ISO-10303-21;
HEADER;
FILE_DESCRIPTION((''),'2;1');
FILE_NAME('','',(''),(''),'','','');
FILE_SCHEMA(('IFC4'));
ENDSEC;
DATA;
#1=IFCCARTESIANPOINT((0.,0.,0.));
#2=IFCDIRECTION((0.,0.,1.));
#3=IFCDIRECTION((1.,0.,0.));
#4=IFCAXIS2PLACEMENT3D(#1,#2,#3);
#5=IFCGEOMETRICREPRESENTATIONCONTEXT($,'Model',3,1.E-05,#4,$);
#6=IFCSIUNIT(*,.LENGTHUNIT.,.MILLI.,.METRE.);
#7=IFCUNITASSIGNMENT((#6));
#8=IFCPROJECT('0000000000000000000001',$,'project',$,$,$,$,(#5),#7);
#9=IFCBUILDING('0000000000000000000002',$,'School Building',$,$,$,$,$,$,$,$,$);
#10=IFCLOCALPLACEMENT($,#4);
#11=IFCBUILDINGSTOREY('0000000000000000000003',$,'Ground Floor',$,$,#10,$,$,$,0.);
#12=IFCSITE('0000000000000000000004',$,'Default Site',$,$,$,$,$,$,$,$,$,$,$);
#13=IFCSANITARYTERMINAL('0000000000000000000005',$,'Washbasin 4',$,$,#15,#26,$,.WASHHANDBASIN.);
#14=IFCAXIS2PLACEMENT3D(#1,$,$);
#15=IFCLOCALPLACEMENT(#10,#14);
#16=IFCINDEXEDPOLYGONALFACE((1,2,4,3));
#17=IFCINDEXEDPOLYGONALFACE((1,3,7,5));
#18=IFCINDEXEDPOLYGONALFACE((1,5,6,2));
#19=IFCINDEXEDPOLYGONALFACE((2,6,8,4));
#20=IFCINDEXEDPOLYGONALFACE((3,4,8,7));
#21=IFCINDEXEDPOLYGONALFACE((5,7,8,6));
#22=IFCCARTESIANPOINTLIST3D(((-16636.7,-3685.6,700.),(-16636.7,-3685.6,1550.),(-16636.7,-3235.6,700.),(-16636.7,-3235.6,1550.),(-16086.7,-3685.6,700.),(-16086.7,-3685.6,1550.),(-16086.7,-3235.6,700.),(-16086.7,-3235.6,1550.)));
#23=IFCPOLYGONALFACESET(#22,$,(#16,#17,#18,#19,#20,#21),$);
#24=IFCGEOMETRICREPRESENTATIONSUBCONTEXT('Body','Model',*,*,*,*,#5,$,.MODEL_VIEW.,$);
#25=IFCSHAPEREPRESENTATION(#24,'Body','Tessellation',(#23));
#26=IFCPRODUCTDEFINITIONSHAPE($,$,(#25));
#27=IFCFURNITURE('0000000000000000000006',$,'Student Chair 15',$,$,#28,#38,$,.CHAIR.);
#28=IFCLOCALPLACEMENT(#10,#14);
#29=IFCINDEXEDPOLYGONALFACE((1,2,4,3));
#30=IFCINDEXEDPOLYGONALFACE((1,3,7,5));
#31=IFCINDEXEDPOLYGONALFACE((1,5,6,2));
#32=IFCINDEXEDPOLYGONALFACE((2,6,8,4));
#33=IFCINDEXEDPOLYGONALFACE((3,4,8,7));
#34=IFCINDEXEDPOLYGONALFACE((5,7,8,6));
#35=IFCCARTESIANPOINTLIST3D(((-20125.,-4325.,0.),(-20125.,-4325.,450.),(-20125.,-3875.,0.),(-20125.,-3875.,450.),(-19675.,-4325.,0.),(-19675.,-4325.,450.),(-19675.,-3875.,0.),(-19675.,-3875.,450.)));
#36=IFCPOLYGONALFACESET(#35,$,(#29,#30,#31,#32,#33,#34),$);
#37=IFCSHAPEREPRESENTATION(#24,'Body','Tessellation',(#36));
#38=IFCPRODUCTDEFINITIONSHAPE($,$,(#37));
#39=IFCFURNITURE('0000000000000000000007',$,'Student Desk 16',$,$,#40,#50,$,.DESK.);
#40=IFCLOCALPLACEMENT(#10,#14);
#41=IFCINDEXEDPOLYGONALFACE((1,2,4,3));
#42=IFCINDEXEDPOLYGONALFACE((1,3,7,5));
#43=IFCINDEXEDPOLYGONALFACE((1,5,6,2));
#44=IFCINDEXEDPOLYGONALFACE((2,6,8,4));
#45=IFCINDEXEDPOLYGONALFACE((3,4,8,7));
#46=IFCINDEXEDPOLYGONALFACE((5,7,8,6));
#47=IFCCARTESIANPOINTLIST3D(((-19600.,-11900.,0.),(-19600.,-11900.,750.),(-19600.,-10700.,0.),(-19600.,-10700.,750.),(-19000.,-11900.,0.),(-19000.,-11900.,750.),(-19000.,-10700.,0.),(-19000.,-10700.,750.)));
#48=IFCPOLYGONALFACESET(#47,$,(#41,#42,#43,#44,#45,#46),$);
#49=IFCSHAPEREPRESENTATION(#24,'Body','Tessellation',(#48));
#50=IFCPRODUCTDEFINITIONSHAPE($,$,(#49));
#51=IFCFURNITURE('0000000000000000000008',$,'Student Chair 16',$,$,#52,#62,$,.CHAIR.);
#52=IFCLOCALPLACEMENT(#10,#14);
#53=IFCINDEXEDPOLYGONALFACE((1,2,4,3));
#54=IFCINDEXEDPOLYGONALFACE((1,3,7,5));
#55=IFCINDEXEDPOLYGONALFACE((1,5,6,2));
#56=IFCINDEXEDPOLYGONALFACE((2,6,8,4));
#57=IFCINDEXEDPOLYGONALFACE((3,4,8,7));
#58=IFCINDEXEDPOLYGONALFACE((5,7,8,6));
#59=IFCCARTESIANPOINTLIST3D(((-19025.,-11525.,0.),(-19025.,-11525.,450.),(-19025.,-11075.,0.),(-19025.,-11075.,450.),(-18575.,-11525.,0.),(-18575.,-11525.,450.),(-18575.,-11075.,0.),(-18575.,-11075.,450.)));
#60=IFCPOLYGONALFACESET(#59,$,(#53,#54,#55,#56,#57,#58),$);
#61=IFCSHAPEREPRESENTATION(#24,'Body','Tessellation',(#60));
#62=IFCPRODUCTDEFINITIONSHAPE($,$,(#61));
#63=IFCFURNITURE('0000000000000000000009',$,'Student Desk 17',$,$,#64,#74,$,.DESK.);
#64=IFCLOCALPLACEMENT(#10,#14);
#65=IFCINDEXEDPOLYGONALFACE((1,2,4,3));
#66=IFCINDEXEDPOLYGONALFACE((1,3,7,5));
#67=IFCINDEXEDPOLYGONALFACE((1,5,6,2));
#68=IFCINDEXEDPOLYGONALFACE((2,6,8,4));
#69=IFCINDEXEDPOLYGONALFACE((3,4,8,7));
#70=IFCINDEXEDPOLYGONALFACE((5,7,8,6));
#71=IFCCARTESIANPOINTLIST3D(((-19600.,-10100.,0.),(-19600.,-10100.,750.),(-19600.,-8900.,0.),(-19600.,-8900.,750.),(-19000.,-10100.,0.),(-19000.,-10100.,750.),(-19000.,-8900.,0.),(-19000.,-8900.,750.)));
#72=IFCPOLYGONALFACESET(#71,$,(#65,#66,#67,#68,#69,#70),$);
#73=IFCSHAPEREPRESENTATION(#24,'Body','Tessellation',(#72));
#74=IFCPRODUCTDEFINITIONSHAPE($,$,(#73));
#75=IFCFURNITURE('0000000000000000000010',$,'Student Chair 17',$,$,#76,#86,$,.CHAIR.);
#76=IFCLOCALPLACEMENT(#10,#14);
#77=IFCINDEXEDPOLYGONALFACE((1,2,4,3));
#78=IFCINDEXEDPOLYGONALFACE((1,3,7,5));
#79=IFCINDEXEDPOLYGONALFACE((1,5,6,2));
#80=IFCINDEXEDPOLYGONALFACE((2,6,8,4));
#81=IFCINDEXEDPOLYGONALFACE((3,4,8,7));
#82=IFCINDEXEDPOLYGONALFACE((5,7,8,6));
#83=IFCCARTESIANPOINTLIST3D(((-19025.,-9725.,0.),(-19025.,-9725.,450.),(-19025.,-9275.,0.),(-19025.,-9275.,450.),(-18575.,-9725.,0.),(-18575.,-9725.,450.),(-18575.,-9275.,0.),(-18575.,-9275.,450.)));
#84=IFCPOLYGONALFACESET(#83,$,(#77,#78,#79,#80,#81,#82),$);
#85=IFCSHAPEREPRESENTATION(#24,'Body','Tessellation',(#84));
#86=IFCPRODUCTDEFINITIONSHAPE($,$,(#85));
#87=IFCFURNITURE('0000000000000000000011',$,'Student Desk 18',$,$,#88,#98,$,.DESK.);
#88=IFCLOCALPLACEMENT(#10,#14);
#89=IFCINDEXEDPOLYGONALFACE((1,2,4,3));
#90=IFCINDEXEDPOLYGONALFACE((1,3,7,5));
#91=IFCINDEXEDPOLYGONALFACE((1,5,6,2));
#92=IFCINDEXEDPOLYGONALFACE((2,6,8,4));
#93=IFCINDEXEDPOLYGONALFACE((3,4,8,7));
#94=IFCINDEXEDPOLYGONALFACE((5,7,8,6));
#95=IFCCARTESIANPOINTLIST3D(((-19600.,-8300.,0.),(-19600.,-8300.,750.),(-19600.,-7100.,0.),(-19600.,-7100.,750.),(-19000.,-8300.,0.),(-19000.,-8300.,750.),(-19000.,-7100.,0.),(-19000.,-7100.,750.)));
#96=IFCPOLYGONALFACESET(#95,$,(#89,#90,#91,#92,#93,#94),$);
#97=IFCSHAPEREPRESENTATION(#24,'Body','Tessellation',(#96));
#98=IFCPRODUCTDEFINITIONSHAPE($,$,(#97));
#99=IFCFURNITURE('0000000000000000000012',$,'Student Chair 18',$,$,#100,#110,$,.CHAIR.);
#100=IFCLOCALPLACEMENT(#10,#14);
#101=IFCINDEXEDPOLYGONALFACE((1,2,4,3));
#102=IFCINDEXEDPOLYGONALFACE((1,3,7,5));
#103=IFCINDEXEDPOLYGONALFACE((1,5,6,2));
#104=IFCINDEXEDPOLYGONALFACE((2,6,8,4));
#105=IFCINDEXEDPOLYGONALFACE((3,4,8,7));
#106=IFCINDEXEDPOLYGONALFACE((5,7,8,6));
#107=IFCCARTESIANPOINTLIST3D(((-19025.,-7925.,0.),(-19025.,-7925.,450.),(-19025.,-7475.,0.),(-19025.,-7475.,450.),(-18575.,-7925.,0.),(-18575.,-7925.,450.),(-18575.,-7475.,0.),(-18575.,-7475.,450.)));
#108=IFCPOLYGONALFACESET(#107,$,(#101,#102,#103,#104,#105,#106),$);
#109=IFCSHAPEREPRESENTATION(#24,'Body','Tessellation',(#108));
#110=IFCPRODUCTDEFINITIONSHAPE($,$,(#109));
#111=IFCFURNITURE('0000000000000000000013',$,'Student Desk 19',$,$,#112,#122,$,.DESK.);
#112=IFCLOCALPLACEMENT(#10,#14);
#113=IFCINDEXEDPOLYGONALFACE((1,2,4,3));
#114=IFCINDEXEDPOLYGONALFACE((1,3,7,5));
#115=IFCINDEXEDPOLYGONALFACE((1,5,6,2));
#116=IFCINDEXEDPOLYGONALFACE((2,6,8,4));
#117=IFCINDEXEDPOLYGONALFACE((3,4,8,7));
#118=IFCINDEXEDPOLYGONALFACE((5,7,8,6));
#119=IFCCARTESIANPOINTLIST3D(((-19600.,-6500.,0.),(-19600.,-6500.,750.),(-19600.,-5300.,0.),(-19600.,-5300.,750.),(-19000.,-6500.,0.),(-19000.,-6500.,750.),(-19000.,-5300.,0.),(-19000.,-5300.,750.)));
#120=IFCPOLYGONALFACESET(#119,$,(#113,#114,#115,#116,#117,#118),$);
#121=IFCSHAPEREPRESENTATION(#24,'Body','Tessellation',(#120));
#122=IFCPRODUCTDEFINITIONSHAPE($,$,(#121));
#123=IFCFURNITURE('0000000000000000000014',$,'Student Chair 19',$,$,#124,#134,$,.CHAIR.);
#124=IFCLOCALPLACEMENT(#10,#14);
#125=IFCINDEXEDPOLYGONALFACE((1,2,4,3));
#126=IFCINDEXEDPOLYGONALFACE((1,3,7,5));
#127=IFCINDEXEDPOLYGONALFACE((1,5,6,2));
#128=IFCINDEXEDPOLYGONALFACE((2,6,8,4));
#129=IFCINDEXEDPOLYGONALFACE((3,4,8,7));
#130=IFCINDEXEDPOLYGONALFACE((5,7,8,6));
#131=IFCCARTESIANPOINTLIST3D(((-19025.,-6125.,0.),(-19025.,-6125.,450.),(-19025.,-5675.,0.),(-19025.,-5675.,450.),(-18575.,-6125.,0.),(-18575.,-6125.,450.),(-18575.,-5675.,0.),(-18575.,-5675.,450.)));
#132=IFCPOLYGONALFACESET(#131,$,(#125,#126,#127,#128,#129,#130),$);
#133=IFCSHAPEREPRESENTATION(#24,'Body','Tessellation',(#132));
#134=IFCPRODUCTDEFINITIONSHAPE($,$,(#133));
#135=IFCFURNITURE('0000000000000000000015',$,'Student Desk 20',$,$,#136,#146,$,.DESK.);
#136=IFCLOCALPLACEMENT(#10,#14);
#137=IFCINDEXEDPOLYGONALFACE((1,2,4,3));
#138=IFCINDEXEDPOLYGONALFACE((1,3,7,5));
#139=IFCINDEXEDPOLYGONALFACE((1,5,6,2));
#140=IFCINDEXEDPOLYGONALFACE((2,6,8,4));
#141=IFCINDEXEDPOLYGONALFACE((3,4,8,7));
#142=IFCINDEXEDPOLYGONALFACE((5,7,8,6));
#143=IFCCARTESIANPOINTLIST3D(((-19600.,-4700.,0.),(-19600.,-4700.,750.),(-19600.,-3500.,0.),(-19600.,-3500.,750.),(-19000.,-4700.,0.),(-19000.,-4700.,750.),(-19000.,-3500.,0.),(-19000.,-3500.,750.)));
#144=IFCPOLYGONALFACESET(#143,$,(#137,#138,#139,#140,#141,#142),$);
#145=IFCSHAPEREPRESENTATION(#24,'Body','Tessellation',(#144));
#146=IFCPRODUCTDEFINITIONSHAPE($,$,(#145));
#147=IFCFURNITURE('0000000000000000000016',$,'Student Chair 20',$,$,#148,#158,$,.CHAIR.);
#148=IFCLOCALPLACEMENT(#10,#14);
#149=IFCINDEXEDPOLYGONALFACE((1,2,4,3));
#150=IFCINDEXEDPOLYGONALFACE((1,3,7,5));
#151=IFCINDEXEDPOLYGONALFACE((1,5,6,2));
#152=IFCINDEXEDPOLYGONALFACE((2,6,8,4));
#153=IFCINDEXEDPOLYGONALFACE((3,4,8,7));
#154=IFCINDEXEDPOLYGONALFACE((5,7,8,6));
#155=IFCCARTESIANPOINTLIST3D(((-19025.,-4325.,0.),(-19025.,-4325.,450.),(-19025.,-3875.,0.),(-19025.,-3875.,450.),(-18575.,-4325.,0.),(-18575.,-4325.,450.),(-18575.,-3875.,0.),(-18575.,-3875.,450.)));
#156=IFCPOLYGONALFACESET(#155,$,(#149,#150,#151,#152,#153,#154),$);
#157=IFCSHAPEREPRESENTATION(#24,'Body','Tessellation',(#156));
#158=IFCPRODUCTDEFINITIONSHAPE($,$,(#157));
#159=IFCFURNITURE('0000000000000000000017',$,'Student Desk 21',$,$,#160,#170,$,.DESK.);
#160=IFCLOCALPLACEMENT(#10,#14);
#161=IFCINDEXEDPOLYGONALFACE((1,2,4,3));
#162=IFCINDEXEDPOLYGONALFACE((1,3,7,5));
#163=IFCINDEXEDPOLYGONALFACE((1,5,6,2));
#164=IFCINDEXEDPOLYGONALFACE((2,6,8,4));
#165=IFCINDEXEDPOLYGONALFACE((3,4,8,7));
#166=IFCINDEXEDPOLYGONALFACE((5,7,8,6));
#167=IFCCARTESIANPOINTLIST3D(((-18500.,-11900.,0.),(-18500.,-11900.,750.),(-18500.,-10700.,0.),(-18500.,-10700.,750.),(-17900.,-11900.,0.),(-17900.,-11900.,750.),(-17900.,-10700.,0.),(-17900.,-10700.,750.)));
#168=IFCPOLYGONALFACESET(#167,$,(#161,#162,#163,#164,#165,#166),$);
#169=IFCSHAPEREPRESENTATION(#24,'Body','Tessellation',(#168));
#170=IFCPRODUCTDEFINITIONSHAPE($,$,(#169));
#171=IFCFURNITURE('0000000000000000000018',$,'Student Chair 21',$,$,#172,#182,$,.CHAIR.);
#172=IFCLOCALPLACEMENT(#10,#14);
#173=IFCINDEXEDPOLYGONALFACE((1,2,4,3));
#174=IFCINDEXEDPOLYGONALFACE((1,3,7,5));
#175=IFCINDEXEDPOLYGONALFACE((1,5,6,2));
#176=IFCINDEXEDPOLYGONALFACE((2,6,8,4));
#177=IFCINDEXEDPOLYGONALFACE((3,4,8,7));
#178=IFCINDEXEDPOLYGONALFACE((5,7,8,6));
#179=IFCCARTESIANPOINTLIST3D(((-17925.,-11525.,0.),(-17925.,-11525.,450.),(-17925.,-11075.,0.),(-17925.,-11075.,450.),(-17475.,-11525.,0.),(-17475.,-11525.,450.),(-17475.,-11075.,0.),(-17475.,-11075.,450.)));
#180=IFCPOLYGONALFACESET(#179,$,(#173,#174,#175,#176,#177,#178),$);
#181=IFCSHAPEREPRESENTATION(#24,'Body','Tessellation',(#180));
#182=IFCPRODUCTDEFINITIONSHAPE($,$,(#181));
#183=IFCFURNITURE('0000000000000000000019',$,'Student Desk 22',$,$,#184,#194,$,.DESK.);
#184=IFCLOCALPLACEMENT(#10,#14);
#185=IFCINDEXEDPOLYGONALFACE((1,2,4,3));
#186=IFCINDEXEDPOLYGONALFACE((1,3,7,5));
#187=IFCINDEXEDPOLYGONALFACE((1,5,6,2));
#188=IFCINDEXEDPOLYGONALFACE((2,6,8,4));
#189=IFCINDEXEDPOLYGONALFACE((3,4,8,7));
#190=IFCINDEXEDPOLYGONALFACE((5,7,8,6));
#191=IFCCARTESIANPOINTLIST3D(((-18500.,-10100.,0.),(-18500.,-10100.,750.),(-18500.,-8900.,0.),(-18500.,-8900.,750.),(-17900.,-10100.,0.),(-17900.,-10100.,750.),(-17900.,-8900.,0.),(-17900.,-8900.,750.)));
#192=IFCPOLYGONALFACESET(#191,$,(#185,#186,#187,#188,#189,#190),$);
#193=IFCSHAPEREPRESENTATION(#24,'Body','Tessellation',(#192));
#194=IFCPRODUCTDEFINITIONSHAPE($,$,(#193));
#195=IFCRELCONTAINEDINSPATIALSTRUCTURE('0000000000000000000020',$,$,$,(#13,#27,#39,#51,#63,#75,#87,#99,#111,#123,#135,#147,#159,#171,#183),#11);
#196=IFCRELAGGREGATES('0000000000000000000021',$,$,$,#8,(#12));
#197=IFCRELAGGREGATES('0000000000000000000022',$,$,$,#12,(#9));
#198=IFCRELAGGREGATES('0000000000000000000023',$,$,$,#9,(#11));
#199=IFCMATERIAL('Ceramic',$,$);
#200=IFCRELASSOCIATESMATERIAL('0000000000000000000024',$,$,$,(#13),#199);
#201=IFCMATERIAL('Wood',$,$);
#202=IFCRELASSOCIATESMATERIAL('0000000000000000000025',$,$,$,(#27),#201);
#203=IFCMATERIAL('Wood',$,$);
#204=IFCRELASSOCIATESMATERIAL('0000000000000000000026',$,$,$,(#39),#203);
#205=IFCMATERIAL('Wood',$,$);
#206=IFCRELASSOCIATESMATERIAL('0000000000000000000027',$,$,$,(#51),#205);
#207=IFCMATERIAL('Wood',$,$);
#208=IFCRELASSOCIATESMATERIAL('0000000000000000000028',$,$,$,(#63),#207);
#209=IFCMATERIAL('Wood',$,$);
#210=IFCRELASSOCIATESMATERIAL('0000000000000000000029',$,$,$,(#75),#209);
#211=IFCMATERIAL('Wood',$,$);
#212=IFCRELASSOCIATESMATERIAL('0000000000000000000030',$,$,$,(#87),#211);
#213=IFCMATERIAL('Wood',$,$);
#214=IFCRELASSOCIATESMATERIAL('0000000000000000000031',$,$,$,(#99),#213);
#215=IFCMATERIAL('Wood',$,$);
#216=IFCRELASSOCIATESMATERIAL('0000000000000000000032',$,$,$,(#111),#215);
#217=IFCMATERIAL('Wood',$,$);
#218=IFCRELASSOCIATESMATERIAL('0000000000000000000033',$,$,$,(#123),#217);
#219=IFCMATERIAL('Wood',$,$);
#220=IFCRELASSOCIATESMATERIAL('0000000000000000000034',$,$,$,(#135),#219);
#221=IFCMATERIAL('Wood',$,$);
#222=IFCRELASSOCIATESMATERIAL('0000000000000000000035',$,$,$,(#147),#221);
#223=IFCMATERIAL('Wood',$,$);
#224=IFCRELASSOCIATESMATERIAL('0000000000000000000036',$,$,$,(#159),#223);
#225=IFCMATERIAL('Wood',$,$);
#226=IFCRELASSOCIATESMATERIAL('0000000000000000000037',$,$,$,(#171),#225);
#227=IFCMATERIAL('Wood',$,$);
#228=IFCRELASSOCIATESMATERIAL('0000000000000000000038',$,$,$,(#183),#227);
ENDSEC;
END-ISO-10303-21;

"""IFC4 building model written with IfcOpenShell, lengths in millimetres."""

from ifc_helpers import new_model, si_unit, frame, origin_with_axes, origin_2d, place, context, subcontext, project, spatial, rectangle, extrude, material, element, save


model = new_model("IFC4")

# Units and contexts
model_context = context("Model", 3, precision=1e-05, world=origin_with_axes())
body_context = subcontext(model_context, "Body", "Model", "MODEL_VIEW")
ifc_project = project(units=[si_unit("LENGTHUNIT", "METRE", prefix="MILLI")], contexts=[model_context])

# Site, building, storey
site = spatial("IfcSite", under=ifc_project, Name="Default Site")
building = spatial("IfcBuilding", under=site, Name="School Building")
storey_placement = place(None, origin_with_axes())
storey = spatial("IfcBuildingStorey", under=building, at=storey_placement, Name="Ground Floor", Elevation=0.0)

# Sanitary terminal
ifc_material_1 = material(Name="Ceramic")
sanitary_terminal_1_placement = place(storey_placement, frame((-16361.7, -3460.6, 700.0), z_axis=(0.0, 0.0, 1.0), x_axis=(0.0, 1.0, 0.0)))
element("IfcSanitaryTerminal", 1, at=sanitary_terminal_1_placement, inside=storey, material=ifc_material_1, Name="Washbasin 4", PredefinedType="WASHHANDBASIN", context=body_context, shape_type="SweptSolid", body=[
    extrude(rectangle(XDim=450.0, YDim=550.0, at=origin_2d()), origin_with_axes(), (0.0, 0.0, 1.0), 850.0),
])

# Furniture
ifc_material_2 = material(Name="Wood")
furniture_1_placement = place(storey_placement, frame((-19900.0, -4100.0, 0.0), z_axis=(0.0, 0.0, 1.0), x_axis=(1.0, 0.0, 0.0)))
element("IfcFurniture", 2, at=furniture_1_placement, inside=storey, material=ifc_material_2, Name="Student Chair 15", PredefinedType="CHAIR", context=body_context, shape_type="SweptSolid", body=[
    extrude(rectangle(XDim=450.0, YDim=450.0, at=origin_2d()), origin_with_axes(), (0.0, 0.0, 1.0), 450.0),
])
ifc_material_3 = material(Name="Wood")
furniture_2_placement = place(storey_placement, frame((-19300.0, -11300.0, 0.0), z_axis=(0.0, 0.0, 1.0), x_axis=(0.0, 1.0, 0.0)))
element("IfcFurniture", 3, at=furniture_2_placement, inside=storey, material=ifc_material_3, Name="Student Desk 16", PredefinedType="DESK", context=body_context, shape_type="SweptSolid", body=[
    extrude(rectangle(XDim=1200.0, YDim=600.0, at=origin_2d()), origin_with_axes(), (0.0, 0.0, 1.0), 750.0),
])
ifc_material_4 = material(Name="Wood")
furniture_3_placement = place(storey_placement, frame((-18800.0, -11300.0, 0.0), z_axis=(0.0, 0.0, 1.0), x_axis=(1.0, 0.0, 0.0)))
element("IfcFurniture", 4, at=furniture_3_placement, inside=storey, material=ifc_material_4, Name="Student Chair 16", PredefinedType="CHAIR", context=body_context, shape_type="SweptSolid", body=[
    extrude(rectangle(XDim=450.0, YDim=450.0, at=origin_2d()), origin_with_axes(), (0.0, 0.0, 1.0), 450.0),
])
ifc_material_5 = material(Name="Wood")
furniture_4_placement = place(storey_placement, frame((-19300.0, -9500.0, 0.0), z_axis=(0.0, 0.0, 1.0), x_axis=(0.0, 1.0, 0.0)))
element("IfcFurniture", 5, at=furniture_4_placement, inside=storey, material=ifc_material_5, Name="Student Desk 17", PredefinedType="DESK", context=body_context, shape_type="SweptSolid", body=[
    extrude(rectangle(XDim=1200.0, YDim=600.0, at=origin_2d()), origin_with_axes(), (0.0, 0.0, 1.0), 750.0),
])
ifc_material_6 = material(Name="Wood")
furniture_5_placement = place(storey_placement, frame((-18800.0, -9500.0, 0.0), z_axis=(0.0, 0.0, 1.0), x_axis=(1.0, 0.0, 0.0)))
element("IfcFurniture", 6, at=furniture_5_placement, inside=storey, material=ifc_material_6, Name="Student Chair 17", PredefinedType="CHAIR", context=body_context, shape_type="SweptSolid", body=[
    extrude(rectangle(XDim=450.0, YDim=450.0, at=origin_2d()), origin_with_axes(), (0.0, 0.0, 1.0), 450.0),
])
ifc_material_7 = material(Name="Wood")
furniture_6_placement = place(storey_placement, frame((-19300.0, -7700.0, 0.0), z_axis=(0.0, 0.0, 1.0), x_axis=(0.0, 1.0, 0.0)))
element("IfcFurniture", 7, at=furniture_6_placement, inside=storey, material=ifc_material_7, Name="Student Desk 18", PredefinedType="DESK", context=body_context, shape_type="SweptSolid", body=[
    extrude(rectangle(XDim=1200.0, YDim=600.0, at=origin_2d()), origin_with_axes(), (0.0, 0.0, 1.0), 750.0),
])
ifc_material_8 = material(Name="Wood")
furniture_7_placement = place(storey_placement, frame((-18800.0, -7700.0, 0.0), z_axis=(0.0, 0.0, 1.0), x_axis=(1.0, 0.0, 0.0)))
element("IfcFurniture", 8, at=furniture_7_placement, inside=storey, material=ifc_material_8, Name="Student Chair 18", PredefinedType="CHAIR", context=body_context, shape_type="SweptSolid", body=[
    extrude(rectangle(XDim=450.0, YDim=450.0, at=origin_2d()), origin_with_axes(), (0.0, 0.0, 1.0), 450.0),
])
ifc_material_9 = material(Name="Wood")
furniture_8_placement = place(storey_placement, frame((-19300.0, -5900.0, 0.0), z_axis=(0.0, 0.0, 1.0), x_axis=(0.0, 1.0, 0.0)))
element("IfcFurniture", 9, at=furniture_8_placement, inside=storey, material=ifc_material_9, Name="Student Desk 19", PredefinedType="DESK", context=body_context, shape_type="SweptSolid", body=[
    extrude(rectangle(XDim=1200.0, YDim=600.0, at=origin_2d()), origin_with_axes(), (0.0, 0.0, 1.0), 750.0),
])
ifc_material_10 = material(Name="Wood")
furniture_9_placement = place(storey_placement, frame((-18800.0, -5900.0, 0.0), z_axis=(0.0, 0.0, 1.0), x_axis=(1.0, 0.0, 0.0)))
element("IfcFurniture", 10, at=furniture_9_placement, inside=storey, material=ifc_material_10, Name="Student Chair 19", PredefinedType="CHAIR", context=body_context, shape_type="SweptSolid", body=[
    extrude(rectangle(XDim=450.0, YDim=450.0, at=origin_2d()), origin_with_axes(), (0.0, 0.0, 1.0), 450.0),
])
ifc_material_11 = material(Name="Wood")
furniture_10_placement = place(storey_placement, frame((-19300.0, -4100.0, 0.0), z_axis=(0.0, 0.0, 1.0), x_axis=(0.0, 1.0, 0.0)))
element("IfcFurniture", 11, at=furniture_10_placement, inside=storey, material=ifc_material_11, Name="Student Desk 20", PredefinedType="DESK", context=body_context, shape_type="SweptSolid", body=[
    extrude(rectangle(XDim=1200.0, YDim=600.0, at=origin_2d()), origin_with_axes(), (0.0, 0.0, 1.0), 750.0),
])
ifc_material_12 = material(Name="Wood")
furniture_11_placement = place(storey_placement, frame((-18800.0, -4100.0, 0.0), z_axis=(0.0, 0.0, 1.0), x_axis=(1.0, 0.0, 0.0)))
element("IfcFurniture", 12, at=furniture_11_placement, inside=storey, material=ifc_material_12, Name="Student Chair 20", PredefinedType="CHAIR", context=body_context, shape_type="SweptSolid", body=[
    extrude(rectangle(XDim=450.0, YDim=450.0, at=origin_2d()), origin_with_axes(), (0.0, 0.0, 1.0), 450.0),
])
ifc_material_13 = material(Name="Wood")
furniture_12_placement = place(storey_placement, frame((-18200.0, -11300.0, 0.0), z_axis=(0.0, 0.0, 1.0), x_axis=(0.0, 1.0, 0.0)))
element("IfcFurniture", 13, at=furniture_12_placement, inside=storey, material=ifc_material_13, Name="Student Desk 21", PredefinedType="DESK", context=body_context, shape_type="SweptSolid", body=[
    extrude(rectangle(XDim=1200.0, YDim=600.0, at=origin_2d()), origin_with_axes(), (0.0, 0.0, 1.0), 750.0),
])
ifc_material_14 = material(Name="Wood")
furniture_13_placement = place(storey_placement, frame((-17700.0, -11300.0, 0.0), z_axis=(0.0, 0.0, 1.0), x_axis=(1.0, 0.0, 0.0)))
element("IfcFurniture", 14, at=furniture_13_placement, inside=storey, material=ifc_material_14, Name="Student Chair 21", PredefinedType="CHAIR", context=body_context, shape_type="SweptSolid", body=[
    extrude(rectangle(XDim=450.0, YDim=450.0, at=origin_2d()), origin_with_axes(), (0.0, 0.0, 1.0), 450.0),
])
ifc_material_15 = material(Name="Wood")
furniture_14_placement = place(storey_placement, frame((-18200.0, -9500.0, 0.0), z_axis=(0.0, 0.0, 1.0), x_axis=(0.0, 1.0, 0.0)))
element("IfcFurniture", 15, at=furniture_14_placement, inside=storey, material=ifc_material_15, Name="Student Desk 22", PredefinedType="DESK", context=body_context, shape_type="SweptSolid", body=[
    extrude(rectangle(XDim=1200.0, YDim=600.0, at=origin_2d()), origin_with_axes(), (0.0, 0.0, 1.0), 750.0),
])

save(model, "model.ifc")
